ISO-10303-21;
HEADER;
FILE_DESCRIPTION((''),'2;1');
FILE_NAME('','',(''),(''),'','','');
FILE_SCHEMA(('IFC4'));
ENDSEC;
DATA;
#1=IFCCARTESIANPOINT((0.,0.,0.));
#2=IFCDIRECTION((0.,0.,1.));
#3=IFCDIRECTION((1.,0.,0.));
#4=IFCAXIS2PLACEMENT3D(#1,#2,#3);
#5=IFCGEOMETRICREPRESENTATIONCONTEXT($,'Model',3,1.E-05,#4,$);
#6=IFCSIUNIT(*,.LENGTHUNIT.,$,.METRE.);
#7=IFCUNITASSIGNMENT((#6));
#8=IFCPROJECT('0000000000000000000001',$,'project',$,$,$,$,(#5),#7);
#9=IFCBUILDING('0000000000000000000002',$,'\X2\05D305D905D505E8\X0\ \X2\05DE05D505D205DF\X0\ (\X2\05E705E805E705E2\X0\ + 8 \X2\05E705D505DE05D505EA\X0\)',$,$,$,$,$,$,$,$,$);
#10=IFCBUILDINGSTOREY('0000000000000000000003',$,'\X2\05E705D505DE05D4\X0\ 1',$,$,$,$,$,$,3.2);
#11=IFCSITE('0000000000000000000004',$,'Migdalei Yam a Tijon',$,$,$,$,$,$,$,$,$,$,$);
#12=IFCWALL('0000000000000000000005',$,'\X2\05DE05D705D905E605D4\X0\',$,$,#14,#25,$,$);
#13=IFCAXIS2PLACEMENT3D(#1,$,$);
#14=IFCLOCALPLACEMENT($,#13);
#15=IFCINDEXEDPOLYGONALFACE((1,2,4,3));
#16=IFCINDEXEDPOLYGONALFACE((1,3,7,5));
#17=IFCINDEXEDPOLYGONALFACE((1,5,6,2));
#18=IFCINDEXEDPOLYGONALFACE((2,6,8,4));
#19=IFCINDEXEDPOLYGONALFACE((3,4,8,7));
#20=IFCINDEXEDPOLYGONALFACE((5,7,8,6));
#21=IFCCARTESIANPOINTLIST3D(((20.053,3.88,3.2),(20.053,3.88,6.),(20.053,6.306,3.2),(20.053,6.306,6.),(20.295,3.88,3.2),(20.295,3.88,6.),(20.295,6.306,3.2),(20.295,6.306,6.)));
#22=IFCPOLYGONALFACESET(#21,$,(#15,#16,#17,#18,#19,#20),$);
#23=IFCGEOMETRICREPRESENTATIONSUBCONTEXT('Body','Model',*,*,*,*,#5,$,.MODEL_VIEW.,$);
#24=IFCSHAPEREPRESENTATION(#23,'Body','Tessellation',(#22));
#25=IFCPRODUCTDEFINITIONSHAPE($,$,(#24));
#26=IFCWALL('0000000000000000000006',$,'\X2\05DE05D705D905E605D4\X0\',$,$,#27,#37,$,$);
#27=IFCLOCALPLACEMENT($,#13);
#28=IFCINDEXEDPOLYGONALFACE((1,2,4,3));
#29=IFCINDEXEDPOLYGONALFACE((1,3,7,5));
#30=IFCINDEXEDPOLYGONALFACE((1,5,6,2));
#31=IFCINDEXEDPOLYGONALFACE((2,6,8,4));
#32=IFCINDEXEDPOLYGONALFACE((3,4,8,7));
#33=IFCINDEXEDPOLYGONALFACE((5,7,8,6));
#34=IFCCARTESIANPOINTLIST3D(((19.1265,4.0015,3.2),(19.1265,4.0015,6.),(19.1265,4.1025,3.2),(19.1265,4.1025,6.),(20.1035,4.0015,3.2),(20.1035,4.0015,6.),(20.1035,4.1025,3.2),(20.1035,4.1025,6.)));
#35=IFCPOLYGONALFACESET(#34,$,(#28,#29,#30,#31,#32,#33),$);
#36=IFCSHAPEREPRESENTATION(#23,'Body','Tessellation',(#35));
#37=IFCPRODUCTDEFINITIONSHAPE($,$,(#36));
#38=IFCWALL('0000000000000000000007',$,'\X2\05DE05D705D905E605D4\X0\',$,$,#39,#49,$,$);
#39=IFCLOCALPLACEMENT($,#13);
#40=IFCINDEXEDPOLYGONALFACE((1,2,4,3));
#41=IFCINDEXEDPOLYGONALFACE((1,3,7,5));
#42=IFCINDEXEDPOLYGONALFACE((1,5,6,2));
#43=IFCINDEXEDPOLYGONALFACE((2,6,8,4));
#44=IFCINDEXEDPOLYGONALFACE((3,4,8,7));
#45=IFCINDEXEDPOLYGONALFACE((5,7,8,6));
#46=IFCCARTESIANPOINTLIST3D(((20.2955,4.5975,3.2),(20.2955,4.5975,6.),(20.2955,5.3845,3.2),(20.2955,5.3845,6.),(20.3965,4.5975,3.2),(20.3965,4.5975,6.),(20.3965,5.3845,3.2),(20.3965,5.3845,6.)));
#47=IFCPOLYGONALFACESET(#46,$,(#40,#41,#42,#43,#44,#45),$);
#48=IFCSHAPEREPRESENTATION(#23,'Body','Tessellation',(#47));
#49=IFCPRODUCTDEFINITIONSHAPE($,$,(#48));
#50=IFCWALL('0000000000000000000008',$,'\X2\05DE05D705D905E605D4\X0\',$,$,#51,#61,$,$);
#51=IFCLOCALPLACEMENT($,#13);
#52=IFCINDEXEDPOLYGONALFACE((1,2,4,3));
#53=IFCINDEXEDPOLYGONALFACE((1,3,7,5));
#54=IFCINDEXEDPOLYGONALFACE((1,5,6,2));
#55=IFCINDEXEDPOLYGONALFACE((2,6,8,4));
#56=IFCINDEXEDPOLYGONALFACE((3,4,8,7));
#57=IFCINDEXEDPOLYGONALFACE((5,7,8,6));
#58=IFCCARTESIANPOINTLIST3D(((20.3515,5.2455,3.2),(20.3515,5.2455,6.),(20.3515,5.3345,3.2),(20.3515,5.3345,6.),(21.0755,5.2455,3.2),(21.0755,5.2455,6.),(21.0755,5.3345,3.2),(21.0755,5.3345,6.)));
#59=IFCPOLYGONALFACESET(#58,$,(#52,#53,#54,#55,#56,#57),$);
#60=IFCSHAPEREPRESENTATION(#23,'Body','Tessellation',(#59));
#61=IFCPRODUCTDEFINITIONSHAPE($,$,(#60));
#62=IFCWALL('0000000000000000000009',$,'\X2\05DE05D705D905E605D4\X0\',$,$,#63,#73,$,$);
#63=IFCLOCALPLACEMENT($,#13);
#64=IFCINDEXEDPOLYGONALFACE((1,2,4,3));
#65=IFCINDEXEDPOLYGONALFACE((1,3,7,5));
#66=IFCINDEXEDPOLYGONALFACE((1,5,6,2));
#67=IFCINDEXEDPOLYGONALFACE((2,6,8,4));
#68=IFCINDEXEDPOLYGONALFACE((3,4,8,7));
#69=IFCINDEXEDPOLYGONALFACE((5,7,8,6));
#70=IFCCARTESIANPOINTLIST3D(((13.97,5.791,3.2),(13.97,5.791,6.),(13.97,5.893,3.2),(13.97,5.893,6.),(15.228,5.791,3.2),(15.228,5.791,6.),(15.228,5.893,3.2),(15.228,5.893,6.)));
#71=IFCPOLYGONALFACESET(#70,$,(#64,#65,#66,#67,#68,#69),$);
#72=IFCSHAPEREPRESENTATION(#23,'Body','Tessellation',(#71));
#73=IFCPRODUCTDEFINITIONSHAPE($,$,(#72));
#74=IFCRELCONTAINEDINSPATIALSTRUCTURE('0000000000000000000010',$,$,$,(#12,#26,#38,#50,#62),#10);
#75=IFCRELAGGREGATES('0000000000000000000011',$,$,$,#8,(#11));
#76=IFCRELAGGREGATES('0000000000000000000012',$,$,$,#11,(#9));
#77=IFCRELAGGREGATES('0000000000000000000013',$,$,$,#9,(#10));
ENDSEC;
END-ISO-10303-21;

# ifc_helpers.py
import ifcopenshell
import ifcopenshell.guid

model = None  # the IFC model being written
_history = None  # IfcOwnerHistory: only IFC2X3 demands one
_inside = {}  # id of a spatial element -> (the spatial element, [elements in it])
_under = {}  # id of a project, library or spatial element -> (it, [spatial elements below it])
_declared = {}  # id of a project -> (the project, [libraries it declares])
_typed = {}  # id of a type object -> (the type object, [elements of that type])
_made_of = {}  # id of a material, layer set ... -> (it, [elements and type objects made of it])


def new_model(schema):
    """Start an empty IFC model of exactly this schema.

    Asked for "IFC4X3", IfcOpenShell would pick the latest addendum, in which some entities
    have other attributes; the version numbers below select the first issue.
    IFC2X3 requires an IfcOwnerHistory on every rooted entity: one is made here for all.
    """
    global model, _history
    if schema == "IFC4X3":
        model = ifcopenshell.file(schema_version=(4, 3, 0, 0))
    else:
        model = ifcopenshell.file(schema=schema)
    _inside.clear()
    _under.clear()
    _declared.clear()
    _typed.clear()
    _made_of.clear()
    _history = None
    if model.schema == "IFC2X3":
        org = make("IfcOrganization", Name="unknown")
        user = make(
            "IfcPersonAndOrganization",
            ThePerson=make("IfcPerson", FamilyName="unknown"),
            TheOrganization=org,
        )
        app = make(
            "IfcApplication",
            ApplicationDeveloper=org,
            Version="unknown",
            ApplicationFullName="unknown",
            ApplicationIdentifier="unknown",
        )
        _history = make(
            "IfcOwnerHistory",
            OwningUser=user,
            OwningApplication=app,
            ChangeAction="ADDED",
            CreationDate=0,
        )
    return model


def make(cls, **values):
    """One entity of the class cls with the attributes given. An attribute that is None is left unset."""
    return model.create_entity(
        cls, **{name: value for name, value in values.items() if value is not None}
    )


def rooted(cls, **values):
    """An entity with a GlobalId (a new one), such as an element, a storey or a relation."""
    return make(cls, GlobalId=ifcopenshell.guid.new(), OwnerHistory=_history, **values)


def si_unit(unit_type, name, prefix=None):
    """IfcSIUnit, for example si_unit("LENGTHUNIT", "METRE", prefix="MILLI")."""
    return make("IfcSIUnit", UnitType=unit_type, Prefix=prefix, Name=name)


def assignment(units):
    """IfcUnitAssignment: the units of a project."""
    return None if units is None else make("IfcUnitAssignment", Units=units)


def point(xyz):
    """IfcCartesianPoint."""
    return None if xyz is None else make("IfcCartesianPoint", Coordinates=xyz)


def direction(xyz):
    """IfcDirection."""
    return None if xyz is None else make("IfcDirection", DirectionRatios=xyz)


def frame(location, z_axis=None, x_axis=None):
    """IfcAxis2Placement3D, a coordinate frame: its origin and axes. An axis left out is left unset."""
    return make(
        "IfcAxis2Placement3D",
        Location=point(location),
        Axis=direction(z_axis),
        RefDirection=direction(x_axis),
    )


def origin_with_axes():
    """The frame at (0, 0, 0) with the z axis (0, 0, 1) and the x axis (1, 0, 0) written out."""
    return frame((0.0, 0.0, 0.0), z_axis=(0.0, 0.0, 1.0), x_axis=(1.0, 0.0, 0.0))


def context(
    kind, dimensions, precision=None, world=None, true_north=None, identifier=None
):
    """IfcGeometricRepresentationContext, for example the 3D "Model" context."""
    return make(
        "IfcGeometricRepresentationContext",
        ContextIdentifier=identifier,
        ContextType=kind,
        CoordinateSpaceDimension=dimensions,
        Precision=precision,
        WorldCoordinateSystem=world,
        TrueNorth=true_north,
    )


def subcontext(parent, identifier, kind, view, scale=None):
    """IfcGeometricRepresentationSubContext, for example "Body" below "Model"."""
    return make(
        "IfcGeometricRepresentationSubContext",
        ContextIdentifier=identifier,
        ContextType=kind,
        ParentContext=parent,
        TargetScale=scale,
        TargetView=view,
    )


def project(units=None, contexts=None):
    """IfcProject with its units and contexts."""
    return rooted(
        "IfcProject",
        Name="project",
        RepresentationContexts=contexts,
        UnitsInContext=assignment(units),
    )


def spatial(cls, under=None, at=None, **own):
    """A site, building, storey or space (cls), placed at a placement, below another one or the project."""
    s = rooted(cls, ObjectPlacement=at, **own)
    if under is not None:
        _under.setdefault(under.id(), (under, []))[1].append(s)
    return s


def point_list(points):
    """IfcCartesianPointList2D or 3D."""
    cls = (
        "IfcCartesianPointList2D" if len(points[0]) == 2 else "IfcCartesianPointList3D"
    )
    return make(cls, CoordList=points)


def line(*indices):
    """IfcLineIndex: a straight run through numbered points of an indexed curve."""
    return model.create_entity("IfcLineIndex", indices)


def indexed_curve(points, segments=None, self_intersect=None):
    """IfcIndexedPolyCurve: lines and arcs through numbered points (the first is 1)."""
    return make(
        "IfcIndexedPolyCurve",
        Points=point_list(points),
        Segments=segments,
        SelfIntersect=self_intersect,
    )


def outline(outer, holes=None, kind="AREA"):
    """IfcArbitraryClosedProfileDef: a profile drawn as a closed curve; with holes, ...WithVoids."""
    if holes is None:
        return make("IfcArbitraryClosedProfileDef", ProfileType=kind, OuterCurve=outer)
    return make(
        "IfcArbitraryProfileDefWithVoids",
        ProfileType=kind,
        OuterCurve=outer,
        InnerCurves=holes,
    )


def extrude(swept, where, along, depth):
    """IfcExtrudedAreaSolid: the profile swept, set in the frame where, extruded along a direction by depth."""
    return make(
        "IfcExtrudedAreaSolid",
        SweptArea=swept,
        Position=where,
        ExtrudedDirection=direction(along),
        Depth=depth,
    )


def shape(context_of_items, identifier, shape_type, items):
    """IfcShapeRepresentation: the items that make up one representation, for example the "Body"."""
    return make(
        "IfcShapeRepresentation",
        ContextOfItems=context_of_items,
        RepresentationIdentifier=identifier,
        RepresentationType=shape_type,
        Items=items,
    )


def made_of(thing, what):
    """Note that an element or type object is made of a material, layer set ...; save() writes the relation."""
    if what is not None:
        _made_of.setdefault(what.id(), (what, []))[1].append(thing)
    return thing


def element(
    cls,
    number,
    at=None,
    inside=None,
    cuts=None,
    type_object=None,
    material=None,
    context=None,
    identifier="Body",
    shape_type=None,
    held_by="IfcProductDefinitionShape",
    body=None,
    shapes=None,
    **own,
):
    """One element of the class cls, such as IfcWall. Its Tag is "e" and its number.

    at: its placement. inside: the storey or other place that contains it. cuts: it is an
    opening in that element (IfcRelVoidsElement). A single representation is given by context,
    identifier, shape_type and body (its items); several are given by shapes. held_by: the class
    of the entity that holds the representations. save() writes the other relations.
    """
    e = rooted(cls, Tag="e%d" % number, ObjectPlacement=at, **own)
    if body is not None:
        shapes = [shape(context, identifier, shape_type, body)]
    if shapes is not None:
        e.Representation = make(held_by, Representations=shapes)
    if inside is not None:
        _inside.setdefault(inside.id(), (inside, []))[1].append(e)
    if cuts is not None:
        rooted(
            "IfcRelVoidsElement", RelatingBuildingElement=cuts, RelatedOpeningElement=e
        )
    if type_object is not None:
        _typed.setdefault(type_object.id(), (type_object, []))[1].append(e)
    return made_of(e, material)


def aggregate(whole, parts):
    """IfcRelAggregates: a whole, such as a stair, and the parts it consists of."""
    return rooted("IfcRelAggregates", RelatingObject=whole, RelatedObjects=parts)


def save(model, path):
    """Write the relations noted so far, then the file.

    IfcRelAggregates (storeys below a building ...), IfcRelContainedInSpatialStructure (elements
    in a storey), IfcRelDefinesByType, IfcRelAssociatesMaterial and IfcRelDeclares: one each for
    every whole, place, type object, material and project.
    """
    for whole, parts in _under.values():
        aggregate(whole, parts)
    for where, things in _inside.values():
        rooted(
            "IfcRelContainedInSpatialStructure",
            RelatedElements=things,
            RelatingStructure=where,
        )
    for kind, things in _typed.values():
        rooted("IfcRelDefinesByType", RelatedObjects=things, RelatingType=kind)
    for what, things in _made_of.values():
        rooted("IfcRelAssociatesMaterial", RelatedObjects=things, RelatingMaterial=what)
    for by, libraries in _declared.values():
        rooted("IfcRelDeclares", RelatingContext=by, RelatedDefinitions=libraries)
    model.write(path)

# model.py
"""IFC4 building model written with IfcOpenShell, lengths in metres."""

from ifc_helpers import new_model, si_unit, frame, origin_with_axes, context, subcontext, project, spatial, line, indexed_curve, outline, extrude, element, save


model = new_model("IFC4")

# Units and contexts
model_context = context("Model", 3, precision=1e-05, world=origin_with_axes())
body_context = subcontext(model_context, "Body", "Model", "MODEL_VIEW")
ifc_project = project(units=[si_unit("LENGTHUNIT", "METRE")], contexts=[model_context])

# Site, building, storey
site = spatial("IfcSite", under=ifc_project, Name="Migdalei Yam a Tijon")
building = spatial("IfcBuilding", under=site, Name="דיור מוגן (קרקע + 8 קומות)")
storey = spatial("IfcBuildingStorey", under=building, Name="קומה 1", Elevation=3.2)

# Walls
element("IfcWall", 1, inside=storey, Name="מחיצה", context=body_context, shape_type="SweptSolid", body=[
    extrude(outline(indexed_curve([(0.0, 0.0), (0.242, 0.0), (0.242, 2.426), (0.0, 2.426)], segments=[line(1, 2, 3, 4, 1)])), frame((20.053, 3.88, 3.2), z_axis=(0.0, 0.0, 1.0), x_axis=(1.0, 0.0, 0.0)), (0.0, 0.0, 1.0), 2.8),
])
element("IfcWall", 2, inside=storey, Name="מחיצה", context=body_context, shape_type="SweptSolid", body=[
    extrude(outline(indexed_curve([(0.0, 0.0), (0.977, 0.0), (0.977, 0.101), (0.0, 0.101)], segments=[line(1, 2, 3, 4, 1)])), frame((19.1265, 4.0015, 3.2), z_axis=(0.0, 0.0, 1.0), x_axis=(1.0, 0.0, 0.0)), (0.0, 0.0, 1.0), 2.8),
])
element("IfcWall", 3, inside=storey, Name="מחיצה", context=body_context, shape_type="SweptSolid", body=[
    extrude(outline(indexed_curve([(0.0, 0.0), (0.101, 0.0), (0.101, 0.787), (0.0, 0.787)], segments=[line(1, 2, 3, 4, 1)])), frame((20.2955, 4.5975, 3.2), z_axis=(0.0, 0.0, 1.0), x_axis=(1.0, 0.0, 0.0)), (0.0, 0.0, 1.0), 2.8),
])
element("IfcWall", 4, inside=storey, Name="מחיצה", context=body_context, shape_type="SweptSolid", body=[
    extrude(outline(indexed_curve([(0.0, 0.0), (0.724, 0.0), (0.724, 0.089), (0.0, 0.089)], segments=[line(1, 2, 3, 4, 1)])), frame((20.3515, 5.2455, 3.2), z_axis=(0.0, 0.0, 1.0), x_axis=(1.0, 0.0, 0.0)), (0.0, 0.0, 1.0), 2.8),
])
element("IfcWall", 5, inside=storey, Name="מחיצה", context=body_context, shape_type="SweptSolid", body=[
    extrude(outline(indexed_curve([(0.0, 0.0), (1.258, 0.0), (1.258, 0.102), (0.0, 0.102)], segments=[line(1, 2, 3, 4, 1)])), frame((13.97, 5.791, 3.2), z_axis=(0.0, 0.0, 1.0), x_axis=(1.0, 0.0, 0.0)), (0.0, 0.0, 1.0), 2.8),
])

save(model, "model.ifc")
